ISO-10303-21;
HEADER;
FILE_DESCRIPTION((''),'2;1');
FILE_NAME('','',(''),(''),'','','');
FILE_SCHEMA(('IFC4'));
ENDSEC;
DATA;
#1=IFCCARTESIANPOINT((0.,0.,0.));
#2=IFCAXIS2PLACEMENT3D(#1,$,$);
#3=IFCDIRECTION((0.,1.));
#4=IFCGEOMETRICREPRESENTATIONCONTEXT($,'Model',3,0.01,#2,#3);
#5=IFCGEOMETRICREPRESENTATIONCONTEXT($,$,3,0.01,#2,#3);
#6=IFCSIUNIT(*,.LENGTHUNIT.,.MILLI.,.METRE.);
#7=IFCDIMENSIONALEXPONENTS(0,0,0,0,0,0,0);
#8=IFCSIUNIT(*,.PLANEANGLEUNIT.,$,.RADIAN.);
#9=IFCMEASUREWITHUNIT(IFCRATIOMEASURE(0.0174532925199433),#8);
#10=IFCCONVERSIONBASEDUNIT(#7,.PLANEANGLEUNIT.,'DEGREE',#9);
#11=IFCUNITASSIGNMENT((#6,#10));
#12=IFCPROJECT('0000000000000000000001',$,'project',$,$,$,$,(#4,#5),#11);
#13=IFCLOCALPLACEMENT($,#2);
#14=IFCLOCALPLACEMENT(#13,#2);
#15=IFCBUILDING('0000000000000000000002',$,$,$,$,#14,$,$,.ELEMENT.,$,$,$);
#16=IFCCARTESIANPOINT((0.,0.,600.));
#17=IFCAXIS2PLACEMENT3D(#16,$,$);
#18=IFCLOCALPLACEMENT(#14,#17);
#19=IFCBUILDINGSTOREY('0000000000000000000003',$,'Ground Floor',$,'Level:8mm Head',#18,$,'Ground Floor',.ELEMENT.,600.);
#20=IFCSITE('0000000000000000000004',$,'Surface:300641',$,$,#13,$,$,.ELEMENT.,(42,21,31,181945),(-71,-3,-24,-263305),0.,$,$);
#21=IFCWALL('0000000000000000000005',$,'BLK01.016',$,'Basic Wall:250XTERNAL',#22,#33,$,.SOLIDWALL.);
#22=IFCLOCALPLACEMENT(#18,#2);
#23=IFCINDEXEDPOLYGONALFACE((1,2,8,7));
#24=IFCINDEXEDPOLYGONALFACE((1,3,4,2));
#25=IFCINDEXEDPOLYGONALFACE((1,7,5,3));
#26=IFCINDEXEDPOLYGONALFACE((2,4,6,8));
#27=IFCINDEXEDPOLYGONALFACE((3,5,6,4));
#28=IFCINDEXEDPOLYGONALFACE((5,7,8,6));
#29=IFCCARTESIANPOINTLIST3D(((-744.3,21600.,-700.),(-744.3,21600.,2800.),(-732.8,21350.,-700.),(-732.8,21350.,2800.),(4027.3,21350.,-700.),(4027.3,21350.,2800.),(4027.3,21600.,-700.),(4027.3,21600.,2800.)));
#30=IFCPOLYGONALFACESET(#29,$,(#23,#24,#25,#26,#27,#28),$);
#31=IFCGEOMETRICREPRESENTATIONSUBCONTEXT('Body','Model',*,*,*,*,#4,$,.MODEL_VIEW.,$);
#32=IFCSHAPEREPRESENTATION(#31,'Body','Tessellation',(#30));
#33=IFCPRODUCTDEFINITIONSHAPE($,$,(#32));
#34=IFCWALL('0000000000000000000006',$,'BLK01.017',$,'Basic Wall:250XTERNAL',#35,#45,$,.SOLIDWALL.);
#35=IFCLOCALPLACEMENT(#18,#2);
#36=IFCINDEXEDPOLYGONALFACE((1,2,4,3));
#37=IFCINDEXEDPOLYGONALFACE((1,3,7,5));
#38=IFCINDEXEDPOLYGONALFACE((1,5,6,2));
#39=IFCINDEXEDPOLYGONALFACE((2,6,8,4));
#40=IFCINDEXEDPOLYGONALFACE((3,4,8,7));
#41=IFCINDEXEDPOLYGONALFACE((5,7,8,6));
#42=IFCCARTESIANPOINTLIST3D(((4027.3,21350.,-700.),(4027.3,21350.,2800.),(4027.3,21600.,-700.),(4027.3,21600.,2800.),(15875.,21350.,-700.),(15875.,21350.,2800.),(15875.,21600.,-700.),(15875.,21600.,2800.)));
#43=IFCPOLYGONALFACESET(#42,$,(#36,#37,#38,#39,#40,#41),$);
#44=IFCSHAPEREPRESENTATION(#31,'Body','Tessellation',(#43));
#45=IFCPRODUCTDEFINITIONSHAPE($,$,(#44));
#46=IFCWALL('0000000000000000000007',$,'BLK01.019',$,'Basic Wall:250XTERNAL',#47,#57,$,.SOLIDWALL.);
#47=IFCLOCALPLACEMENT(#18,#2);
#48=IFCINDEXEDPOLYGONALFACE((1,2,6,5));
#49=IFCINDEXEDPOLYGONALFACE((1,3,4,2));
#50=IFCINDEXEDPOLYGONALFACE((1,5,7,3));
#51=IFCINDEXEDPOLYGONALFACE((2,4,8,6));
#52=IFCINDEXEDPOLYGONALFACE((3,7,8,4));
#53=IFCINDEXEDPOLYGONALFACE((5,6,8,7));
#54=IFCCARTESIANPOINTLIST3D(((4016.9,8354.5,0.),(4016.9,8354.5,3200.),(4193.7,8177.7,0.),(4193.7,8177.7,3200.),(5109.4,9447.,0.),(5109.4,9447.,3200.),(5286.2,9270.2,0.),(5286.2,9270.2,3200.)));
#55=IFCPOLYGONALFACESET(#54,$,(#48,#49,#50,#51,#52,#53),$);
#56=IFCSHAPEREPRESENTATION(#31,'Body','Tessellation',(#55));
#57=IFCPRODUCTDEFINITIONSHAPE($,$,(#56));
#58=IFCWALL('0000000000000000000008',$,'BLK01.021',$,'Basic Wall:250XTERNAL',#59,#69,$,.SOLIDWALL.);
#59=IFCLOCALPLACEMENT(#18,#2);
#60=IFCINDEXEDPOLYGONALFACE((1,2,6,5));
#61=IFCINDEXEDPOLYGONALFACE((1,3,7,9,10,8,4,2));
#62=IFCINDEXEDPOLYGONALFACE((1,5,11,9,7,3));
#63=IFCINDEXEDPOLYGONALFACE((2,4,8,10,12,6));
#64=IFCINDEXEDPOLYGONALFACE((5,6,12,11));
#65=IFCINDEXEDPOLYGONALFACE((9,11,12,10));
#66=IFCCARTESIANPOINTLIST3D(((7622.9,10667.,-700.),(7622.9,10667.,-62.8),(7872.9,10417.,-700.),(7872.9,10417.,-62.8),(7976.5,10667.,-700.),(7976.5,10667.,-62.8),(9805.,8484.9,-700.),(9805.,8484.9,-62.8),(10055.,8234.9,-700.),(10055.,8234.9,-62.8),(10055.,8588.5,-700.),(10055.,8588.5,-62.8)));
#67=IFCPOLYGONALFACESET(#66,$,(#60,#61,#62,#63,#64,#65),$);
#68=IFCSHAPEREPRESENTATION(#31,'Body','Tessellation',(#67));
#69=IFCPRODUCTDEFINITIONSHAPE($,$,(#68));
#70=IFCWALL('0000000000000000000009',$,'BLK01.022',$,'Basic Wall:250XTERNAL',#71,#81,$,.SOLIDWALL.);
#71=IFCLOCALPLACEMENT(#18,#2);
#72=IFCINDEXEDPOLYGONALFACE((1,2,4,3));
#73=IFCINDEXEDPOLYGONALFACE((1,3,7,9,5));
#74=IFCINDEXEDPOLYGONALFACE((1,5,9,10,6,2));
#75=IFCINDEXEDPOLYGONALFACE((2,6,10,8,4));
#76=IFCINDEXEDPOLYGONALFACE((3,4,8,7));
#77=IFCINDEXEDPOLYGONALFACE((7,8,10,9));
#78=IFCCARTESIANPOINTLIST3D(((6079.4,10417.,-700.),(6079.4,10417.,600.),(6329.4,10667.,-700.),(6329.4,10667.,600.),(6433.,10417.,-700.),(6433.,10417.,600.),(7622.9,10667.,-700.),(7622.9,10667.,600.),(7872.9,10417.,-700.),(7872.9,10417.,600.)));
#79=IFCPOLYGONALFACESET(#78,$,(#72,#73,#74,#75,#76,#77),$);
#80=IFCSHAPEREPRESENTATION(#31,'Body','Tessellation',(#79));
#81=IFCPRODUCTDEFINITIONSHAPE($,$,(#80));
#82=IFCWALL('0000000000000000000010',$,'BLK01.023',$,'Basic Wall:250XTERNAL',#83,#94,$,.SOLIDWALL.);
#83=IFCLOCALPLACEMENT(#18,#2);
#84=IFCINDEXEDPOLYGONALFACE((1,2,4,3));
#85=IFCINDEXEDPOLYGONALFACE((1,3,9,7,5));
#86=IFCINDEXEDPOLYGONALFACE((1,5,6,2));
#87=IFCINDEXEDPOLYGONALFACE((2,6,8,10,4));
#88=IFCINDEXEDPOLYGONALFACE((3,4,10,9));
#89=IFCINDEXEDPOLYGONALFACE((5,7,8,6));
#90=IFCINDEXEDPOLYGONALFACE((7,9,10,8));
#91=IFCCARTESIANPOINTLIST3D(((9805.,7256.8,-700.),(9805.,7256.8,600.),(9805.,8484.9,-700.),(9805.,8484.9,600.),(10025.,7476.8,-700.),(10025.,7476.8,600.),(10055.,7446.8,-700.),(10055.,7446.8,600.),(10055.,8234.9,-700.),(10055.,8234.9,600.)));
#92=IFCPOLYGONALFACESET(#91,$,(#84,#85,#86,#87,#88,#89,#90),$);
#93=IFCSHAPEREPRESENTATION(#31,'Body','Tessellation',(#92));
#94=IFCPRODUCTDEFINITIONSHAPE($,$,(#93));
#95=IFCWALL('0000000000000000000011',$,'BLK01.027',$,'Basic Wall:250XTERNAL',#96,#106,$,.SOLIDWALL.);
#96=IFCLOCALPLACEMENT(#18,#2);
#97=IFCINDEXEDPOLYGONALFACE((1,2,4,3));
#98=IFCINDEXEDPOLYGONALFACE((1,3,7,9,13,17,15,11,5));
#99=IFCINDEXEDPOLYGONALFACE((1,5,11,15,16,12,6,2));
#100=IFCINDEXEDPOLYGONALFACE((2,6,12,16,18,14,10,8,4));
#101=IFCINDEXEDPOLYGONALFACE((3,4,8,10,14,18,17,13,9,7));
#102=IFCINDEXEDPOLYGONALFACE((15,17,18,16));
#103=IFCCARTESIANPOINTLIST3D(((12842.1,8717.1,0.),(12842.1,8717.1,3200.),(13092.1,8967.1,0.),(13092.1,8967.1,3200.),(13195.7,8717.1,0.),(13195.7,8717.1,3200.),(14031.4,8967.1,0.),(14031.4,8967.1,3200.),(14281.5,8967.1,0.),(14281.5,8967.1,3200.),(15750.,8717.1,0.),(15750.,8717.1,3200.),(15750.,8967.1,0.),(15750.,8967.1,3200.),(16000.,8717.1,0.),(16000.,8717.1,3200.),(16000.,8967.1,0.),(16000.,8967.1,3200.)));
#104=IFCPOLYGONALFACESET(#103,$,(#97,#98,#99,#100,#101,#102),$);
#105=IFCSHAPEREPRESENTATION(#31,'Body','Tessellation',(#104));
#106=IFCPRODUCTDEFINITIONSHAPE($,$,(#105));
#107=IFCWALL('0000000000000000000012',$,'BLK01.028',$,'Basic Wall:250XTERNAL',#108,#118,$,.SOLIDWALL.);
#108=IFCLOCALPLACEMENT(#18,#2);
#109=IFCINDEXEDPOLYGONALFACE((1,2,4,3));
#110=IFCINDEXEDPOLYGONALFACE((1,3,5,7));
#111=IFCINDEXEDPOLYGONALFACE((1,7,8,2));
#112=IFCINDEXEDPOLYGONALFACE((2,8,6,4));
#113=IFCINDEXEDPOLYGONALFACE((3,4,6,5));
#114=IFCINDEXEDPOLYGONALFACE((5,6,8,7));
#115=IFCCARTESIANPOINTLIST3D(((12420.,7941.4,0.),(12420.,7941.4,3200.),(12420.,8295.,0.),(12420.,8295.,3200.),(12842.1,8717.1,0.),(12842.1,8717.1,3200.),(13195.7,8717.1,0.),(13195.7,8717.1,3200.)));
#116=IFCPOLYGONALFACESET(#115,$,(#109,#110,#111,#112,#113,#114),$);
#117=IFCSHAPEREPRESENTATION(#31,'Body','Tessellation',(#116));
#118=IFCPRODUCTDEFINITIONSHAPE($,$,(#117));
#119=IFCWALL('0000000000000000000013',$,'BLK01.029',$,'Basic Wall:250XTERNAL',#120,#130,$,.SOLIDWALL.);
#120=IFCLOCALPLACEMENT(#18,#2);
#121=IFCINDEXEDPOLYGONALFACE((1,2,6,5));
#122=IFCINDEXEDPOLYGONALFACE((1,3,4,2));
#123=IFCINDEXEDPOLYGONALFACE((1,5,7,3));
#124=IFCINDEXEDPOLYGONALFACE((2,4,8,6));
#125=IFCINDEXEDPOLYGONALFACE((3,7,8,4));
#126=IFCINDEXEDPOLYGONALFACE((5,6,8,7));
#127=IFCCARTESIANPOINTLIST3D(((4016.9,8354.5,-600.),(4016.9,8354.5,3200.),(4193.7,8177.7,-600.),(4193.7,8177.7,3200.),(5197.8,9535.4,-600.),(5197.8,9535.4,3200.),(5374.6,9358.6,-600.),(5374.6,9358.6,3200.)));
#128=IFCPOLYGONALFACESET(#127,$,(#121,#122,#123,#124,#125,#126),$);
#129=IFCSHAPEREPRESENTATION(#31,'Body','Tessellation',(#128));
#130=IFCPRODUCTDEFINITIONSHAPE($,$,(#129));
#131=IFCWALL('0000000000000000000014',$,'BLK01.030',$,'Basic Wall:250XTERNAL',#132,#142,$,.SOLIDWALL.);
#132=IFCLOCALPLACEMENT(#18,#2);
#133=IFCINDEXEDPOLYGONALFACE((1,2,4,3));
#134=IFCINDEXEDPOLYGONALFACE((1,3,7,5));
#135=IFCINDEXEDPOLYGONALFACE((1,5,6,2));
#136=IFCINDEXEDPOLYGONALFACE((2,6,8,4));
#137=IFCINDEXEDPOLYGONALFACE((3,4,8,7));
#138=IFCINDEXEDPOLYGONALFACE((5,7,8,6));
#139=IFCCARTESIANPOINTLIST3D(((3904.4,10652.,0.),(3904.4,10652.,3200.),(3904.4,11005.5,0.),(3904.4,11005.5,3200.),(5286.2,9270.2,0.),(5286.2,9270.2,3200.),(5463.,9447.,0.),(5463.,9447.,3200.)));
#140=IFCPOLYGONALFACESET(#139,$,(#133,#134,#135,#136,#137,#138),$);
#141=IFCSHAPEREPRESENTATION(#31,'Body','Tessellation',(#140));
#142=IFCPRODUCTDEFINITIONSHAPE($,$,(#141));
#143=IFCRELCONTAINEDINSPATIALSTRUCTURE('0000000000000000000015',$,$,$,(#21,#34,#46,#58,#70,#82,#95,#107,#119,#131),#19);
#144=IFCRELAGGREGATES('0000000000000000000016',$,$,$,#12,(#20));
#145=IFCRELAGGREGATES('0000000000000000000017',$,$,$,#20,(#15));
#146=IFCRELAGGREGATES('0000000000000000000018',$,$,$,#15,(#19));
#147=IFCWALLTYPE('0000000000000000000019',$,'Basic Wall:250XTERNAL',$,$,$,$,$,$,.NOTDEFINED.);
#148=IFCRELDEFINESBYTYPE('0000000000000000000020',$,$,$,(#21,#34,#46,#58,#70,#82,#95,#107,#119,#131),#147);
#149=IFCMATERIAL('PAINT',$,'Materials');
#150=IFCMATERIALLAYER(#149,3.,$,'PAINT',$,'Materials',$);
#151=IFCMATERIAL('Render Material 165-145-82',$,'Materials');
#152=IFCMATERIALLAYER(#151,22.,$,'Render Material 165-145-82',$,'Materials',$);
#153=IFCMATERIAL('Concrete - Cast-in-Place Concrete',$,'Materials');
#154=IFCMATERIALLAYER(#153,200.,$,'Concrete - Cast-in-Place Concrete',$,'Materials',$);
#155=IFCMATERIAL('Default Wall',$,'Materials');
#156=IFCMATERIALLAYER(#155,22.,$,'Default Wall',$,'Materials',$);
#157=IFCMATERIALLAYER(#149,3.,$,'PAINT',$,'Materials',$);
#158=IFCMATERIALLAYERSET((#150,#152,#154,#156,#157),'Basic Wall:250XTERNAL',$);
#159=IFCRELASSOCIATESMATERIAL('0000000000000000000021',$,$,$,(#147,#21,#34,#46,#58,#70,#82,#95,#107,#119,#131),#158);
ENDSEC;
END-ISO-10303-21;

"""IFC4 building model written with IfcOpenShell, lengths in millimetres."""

from ifc_helpers import new_model, entity, si_unit, converted_unit, direction, frame, frame_2d, origin, place, context, subcontext, project, spatial, polyline, rectangle, outline, extrude, clip, halfspace, material, layer, layer_set, layer_usage, type_object, element, save


model = new_model("IFC4")

# Units and contexts
model_context = context("Model", 3, precision=0.01, world=origin(), true_north=direction((0.0, 1.0)))
context_of_model = context(None, 3, precision=0.01, world=origin(), true_north=direction((0.0, 1.0)))
body_context = subcontext(model_context, "Body", "Model", "MODEL_VIEW")
ifc_project = project(units=[si_unit("LENGTHUNIT", "METRE", prefix="MILLI"), converted_unit("PLANEANGLEUNIT", "DEGREE", entity("IfcRatioMeasure", 0.0174532925199433), si_unit("PLANEANGLEUNIT", "RADIAN"), dimensions=[0, 0, 0, 0, 0, 0, 0])], contexts=[model_context, context_of_model])

# Site, building, storey
site_placement = place(None, origin())
site = spatial("IfcSite", under=ifc_project, at=site_placement, Name="Surface:300641", CompositionType="ELEMENT", RefLatitude=(42, 21, 31, 181945), RefLongitude=(-71, -3, -24, -263305), RefElevation=0.0)
building_placement = place(site_placement, origin())
building = spatial("IfcBuilding", under=site, at=building_placement, CompositionType="ELEMENT")
storey_placement = place(building_placement, frame((0.0, 0.0, 600.0)))
storey = spatial("IfcBuildingStorey", under=building, at=storey_placement, Name="Ground Floor", ObjectType="Level:8mm Head", LongName="Ground Floor", CompositionType="ELEMENT", Elevation=600.0)

# Walls
ifc_material_1 = material(Name="PAINT", Category="Materials")
ifc_layer_1 = layer(ifc_material_1, 3.0, Name="PAINT", Category="Materials")
ifc_material_2 = material(Name="Render Material 165-145-82", Category="Materials")
ifc_layer_2 = layer(ifc_material_2, 22.0, Name="Render Material 165-145-82", Category="Materials")
ifc_material_3 = material(Name="Concrete - Cast-in-Place Concrete", Category="Materials")
ifc_layer_3 = layer(ifc_material_3, 200.0, Name="Concrete - Cast-in-Place Concrete", Category="Materials")
ifc_material_4 = material(Name="Default Wall", Category="Materials")
ifc_layer_4 = layer(ifc_material_4, 22.0, Name="Default Wall", Category="Materials")
ifc_layer_5 = layer(ifc_material_1, 3.0, Name="PAINT", Category="Materials")
ifc_layer_set_1 = layer_set([ifc_layer_1, ifc_layer_2, ifc_layer_3, ifc_layer_4, ifc_layer_5], Name="Basic Wall:250XTERNAL")
ifc_layer_usage_1 = layer_usage(ifc_layer_set_1, "AXIS2", "NEGATIVE", 125.0)
wall_type_1 = type_object("IfcWallType", Name="Basic Wall:250XTERNAL", PredefinedType="NOTDEFINED", material=ifc_layer_set_1)
wall_1_placement = place(storey_placement, frame((-744.3, 21475.0, -700.0)))
element("IfcWall", 1, at=wall_1_placement, inside=storey, type_object=wall_type_1, material=ifc_layer_usage_1, Name="BLK01.016", ObjectType="Basic Wall:250XTERNAL", PredefinedType="SOLIDWALL", context=body_context, shape_type="SweptSolid", body=[
    extrude(outline(polyline([(4771.6, -125.0), (4771.6, 125.0), (0.0, 125.0), (11.5, -125.0), (4771.6, -125.0)])), origin(), (0.0, 0.0, 1.0), 3500.0),
])
ifc_layer_usage_2 = layer_usage(ifc_layer_set_1, "AXIS2", "NEGATIVE", 125.0)
wall_2_placement = place(storey_placement, frame((4027.3, 21475.0, -700.0)))
element("IfcWall", 2, at=wall_2_placement, inside=storey, type_object=wall_type_1, material=ifc_layer_usage_2, Name="BLK01.017", ObjectType="Basic Wall:250XTERNAL", PredefinedType="SOLIDWALL", context=body_context, shape_type="SweptSolid", body=[
    extrude(rectangle(XDim=11847.7, YDim=250.0, at=frame_2d((5923.8, 0.0), x_axis=(-1.0, 0.0))), origin(), (0.0, 0.0, 1.0), 3500.0),
])
ifc_layer_usage_3 = layer_usage(ifc_layer_set_1, "AXIS2", "NEGATIVE", 125.0)
wall_3_placement = place(storey_placement, frame((4105.3, 8266.1, 0.0), z_axis=(0.0, 0.0, 1.0), x_axis=(0.707107, 0.707107, 0.0)))
element("IfcWall", 3, at=wall_3_placement, inside=storey, type_object=wall_type_1, material=ifc_layer_usage_3, Name="BLK01.019", ObjectType="Basic Wall:250XTERNAL", PredefinedType="SOLIDWALL", context=body_context, shape_type="Clipping", body=[
    clip(extrude(rectangle(XDim=1545.0, YDim=250.0, at=frame_2d((772.5, 0.0), x_axis=(-1.0, 0.0))), origin(), (0.0, 0.0, 1.0), 3200.0), halfspace(origin(), True)),
])
ifc_layer_usage_4 = layer_usage(ifc_layer_set_1, "AXIS2", "NEGATIVE", 125.0)
wall_4_placement = place(storey_placement, frame((10143.4, 8323.3, -700.0), z_axis=(0.0, 0.0, 1.0), x_axis=(-0.707107, 0.707107, 0.0)))
element("IfcWall", 4, at=wall_4_placement, inside=storey, type_object=wall_type_1, material=ifc_layer_usage_4, Name="BLK01.021", ObjectType="Basic Wall:250XTERNAL", PredefinedType="SOLIDWALL", context=body_context, shape_type="SweptSolid", body=[
    extrude(outline(polyline([(3189.5, -125.0), (3439.5, 125.0), (3086.0, 125.0), (353.6, 125.0), (0.0, 125.0), (250.0, -125.0), (3189.5, -125.0)])), origin(), (0.0, 0.0, 1.0), 637.2),
])
ifc_layer_usage_5 = layer_usage(ifc_layer_set_1, "AXIS2", "POSITIVE", -125.0)
wall_5_placement = place(storey_placement, frame((7872.9, 10542.0, -700.0), z_axis=(0.0, 0.0, 1.0), x_axis=(-1.0, 0.0, 0.0)))
element("IfcWall", 5, at=wall_5_placement, inside=storey, type_object=wall_type_1, material=ifc_layer_usage_5, Name="BLK01.022", ObjectType="Basic Wall:250XTERNAL", PredefinedType="SOLIDWALL", context=body_context, shape_type="SweptSolid", body=[
    extrude(outline(polyline([(1543.5, -125.0), (1793.5, 125.0), (1439.9, 125.0), (0.0, 125.0), (250.0, -125.0), (1543.5, -125.0)])), origin(), (0.0, 0.0, 1.0), 1300.0),
])
ifc_layer_usage_6 = layer_usage(ifc_layer_set_1, "AXIS2", "NEGATIVE", 125.0)
wall_6_placement = place(storey_placement, frame((9930.0, 8484.9, -700.0), z_axis=(0.0, 0.0, 1.0), x_axis=(0.0, -1.0, 0.0)))
element("IfcWall", 6, at=wall_6_placement, inside=storey, type_object=wall_type_1, material=ifc_layer_usage_6, Name="BLK01.023", ObjectType="Basic Wall:250XTERNAL", PredefinedType="SOLIDWALL", context=body_context, shape_type="SweptSolid", body=[
    extrude(outline(polyline([(1228.2, -125.0), (1008.2, 95.0), (1038.2, 125.0), (250.0, 125.0), (0.0, -125.0), (1228.2, -125.0)])), origin(), (0.0, 0.0, 1.0), 1300.0),
])
ifc_layer_usage_7 = layer_usage(ifc_layer_set_1, "AXIS2", "NEGATIVE", 125.0)
wall_7_placement = place(storey_placement, frame((16000.0, 8842.1, 0.0), z_axis=(0.0, 0.0, 1.0), x_axis=(-1.0, 0.0, 0.0)))
element("IfcWall", 7, at=wall_7_placement, inside=storey, type_object=wall_type_1, material=ifc_layer_usage_7, Name="BLK01.027", ObjectType="Basic Wall:250XTERNAL", PredefinedType="SOLIDWALL", context=body_context, shape_type="SweptSolid", body=[
    extrude(outline(polyline([(2907.9, -125.0), (3157.9, 125.0), (2804.3, 125.0), (250.0, 125.0), (0.0, 125.0), (0.0, -125.0), (250.0, -125.0), (1718.5, -125.0), (1968.6, -125.0), (2907.9, -125.0)])), origin(), (0.0, 0.0, 1.0), 3200.0),
])
ifc_layer_usage_8 = layer_usage(ifc_layer_set_1, "AXIS2", "NEGATIVE", 125.0)
wall_8_placement = place(storey_placement, frame((12331.6, 8029.8, 0.0), z_axis=(0.0, 0.0, 1.0), x_axis=(0.707107, 0.707107, 0.0)))
element("IfcWall", 8, at=wall_8_placement, inside=storey, type_object=wall_type_1, material=ifc_layer_usage_8, Name="BLK01.028", ObjectType="Basic Wall:250XTERNAL", PredefinedType="SOLIDWALL", context=body_context, shape_type="Clipping", body=[
    clip(extrude(outline(polyline([(1097.0, -125.0), (847.0, 125.0), (250.0, 125.0), (0.0, -125.0), (1097.0, -125.0)])), origin(), (0.0, 0.0, 1.0), 3200.0), halfspace(origin(), True)),
])
ifc_layer_usage_9 = layer_usage(ifc_layer_set_1, "AXIS2", "NEGATIVE", 125.0)
wall_9_placement = place(storey_placement, frame((4105.3, 8266.1, -600.0), z_axis=(0.0, 0.0, 1.0), x_axis=(0.707107, 0.707107, 0.0)))
element("IfcWall", 9, at=wall_9_placement, inside=storey, type_object=wall_type_1, material=ifc_layer_usage_9, Name="BLK01.029", ObjectType="Basic Wall:250XTERNAL", PredefinedType="SOLIDWALL", context=body_context, shape_type="Clipping", body=[
    clip(extrude(rectangle(XDim=1670.0, YDim=250.0, at=frame_2d((835.0, 0.0), x_axis=(-1.0, 0.0))), origin(), (0.0, 0.0, 1.0), 3800.0), halfspace(frame((0.0, 0.0, -600.0)), True)),
])
ifc_layer_usage_10 = layer_usage(ifc_layer_set_1, "AXIS2", "NEGATIVE", 125.0)
wall_10_placement = place(storey_placement, frame((5374.6, 9358.6, 0.0), z_axis=(0.0, 0.0, 1.0), x_axis=(-0.707107, 0.707107, 0.0)))
element("IfcWall", 10, at=wall_10_placement, inside=storey, type_object=wall_type_1, material=ifc_layer_usage_10, Name="BLK01.030", ObjectType="Basic Wall:250XTERNAL", PredefinedType="SOLIDWALL", context=body_context, shape_type="Clipping", body=[
    clip(extrude(outline(polyline([(2204.1, -125.0), (1954.1, 125.0), (250.0, 125.0), (0.0, 125.0), (0.0, 0.0), (0.0, -125.0), (250.0, -125.0), (1850.5, -125.0), (2204.1, -125.0)])), origin(), (0.0, 0.0, 1.0), 3200.0), halfspace(origin(), True)),
])

save(model, "model.ifc")
